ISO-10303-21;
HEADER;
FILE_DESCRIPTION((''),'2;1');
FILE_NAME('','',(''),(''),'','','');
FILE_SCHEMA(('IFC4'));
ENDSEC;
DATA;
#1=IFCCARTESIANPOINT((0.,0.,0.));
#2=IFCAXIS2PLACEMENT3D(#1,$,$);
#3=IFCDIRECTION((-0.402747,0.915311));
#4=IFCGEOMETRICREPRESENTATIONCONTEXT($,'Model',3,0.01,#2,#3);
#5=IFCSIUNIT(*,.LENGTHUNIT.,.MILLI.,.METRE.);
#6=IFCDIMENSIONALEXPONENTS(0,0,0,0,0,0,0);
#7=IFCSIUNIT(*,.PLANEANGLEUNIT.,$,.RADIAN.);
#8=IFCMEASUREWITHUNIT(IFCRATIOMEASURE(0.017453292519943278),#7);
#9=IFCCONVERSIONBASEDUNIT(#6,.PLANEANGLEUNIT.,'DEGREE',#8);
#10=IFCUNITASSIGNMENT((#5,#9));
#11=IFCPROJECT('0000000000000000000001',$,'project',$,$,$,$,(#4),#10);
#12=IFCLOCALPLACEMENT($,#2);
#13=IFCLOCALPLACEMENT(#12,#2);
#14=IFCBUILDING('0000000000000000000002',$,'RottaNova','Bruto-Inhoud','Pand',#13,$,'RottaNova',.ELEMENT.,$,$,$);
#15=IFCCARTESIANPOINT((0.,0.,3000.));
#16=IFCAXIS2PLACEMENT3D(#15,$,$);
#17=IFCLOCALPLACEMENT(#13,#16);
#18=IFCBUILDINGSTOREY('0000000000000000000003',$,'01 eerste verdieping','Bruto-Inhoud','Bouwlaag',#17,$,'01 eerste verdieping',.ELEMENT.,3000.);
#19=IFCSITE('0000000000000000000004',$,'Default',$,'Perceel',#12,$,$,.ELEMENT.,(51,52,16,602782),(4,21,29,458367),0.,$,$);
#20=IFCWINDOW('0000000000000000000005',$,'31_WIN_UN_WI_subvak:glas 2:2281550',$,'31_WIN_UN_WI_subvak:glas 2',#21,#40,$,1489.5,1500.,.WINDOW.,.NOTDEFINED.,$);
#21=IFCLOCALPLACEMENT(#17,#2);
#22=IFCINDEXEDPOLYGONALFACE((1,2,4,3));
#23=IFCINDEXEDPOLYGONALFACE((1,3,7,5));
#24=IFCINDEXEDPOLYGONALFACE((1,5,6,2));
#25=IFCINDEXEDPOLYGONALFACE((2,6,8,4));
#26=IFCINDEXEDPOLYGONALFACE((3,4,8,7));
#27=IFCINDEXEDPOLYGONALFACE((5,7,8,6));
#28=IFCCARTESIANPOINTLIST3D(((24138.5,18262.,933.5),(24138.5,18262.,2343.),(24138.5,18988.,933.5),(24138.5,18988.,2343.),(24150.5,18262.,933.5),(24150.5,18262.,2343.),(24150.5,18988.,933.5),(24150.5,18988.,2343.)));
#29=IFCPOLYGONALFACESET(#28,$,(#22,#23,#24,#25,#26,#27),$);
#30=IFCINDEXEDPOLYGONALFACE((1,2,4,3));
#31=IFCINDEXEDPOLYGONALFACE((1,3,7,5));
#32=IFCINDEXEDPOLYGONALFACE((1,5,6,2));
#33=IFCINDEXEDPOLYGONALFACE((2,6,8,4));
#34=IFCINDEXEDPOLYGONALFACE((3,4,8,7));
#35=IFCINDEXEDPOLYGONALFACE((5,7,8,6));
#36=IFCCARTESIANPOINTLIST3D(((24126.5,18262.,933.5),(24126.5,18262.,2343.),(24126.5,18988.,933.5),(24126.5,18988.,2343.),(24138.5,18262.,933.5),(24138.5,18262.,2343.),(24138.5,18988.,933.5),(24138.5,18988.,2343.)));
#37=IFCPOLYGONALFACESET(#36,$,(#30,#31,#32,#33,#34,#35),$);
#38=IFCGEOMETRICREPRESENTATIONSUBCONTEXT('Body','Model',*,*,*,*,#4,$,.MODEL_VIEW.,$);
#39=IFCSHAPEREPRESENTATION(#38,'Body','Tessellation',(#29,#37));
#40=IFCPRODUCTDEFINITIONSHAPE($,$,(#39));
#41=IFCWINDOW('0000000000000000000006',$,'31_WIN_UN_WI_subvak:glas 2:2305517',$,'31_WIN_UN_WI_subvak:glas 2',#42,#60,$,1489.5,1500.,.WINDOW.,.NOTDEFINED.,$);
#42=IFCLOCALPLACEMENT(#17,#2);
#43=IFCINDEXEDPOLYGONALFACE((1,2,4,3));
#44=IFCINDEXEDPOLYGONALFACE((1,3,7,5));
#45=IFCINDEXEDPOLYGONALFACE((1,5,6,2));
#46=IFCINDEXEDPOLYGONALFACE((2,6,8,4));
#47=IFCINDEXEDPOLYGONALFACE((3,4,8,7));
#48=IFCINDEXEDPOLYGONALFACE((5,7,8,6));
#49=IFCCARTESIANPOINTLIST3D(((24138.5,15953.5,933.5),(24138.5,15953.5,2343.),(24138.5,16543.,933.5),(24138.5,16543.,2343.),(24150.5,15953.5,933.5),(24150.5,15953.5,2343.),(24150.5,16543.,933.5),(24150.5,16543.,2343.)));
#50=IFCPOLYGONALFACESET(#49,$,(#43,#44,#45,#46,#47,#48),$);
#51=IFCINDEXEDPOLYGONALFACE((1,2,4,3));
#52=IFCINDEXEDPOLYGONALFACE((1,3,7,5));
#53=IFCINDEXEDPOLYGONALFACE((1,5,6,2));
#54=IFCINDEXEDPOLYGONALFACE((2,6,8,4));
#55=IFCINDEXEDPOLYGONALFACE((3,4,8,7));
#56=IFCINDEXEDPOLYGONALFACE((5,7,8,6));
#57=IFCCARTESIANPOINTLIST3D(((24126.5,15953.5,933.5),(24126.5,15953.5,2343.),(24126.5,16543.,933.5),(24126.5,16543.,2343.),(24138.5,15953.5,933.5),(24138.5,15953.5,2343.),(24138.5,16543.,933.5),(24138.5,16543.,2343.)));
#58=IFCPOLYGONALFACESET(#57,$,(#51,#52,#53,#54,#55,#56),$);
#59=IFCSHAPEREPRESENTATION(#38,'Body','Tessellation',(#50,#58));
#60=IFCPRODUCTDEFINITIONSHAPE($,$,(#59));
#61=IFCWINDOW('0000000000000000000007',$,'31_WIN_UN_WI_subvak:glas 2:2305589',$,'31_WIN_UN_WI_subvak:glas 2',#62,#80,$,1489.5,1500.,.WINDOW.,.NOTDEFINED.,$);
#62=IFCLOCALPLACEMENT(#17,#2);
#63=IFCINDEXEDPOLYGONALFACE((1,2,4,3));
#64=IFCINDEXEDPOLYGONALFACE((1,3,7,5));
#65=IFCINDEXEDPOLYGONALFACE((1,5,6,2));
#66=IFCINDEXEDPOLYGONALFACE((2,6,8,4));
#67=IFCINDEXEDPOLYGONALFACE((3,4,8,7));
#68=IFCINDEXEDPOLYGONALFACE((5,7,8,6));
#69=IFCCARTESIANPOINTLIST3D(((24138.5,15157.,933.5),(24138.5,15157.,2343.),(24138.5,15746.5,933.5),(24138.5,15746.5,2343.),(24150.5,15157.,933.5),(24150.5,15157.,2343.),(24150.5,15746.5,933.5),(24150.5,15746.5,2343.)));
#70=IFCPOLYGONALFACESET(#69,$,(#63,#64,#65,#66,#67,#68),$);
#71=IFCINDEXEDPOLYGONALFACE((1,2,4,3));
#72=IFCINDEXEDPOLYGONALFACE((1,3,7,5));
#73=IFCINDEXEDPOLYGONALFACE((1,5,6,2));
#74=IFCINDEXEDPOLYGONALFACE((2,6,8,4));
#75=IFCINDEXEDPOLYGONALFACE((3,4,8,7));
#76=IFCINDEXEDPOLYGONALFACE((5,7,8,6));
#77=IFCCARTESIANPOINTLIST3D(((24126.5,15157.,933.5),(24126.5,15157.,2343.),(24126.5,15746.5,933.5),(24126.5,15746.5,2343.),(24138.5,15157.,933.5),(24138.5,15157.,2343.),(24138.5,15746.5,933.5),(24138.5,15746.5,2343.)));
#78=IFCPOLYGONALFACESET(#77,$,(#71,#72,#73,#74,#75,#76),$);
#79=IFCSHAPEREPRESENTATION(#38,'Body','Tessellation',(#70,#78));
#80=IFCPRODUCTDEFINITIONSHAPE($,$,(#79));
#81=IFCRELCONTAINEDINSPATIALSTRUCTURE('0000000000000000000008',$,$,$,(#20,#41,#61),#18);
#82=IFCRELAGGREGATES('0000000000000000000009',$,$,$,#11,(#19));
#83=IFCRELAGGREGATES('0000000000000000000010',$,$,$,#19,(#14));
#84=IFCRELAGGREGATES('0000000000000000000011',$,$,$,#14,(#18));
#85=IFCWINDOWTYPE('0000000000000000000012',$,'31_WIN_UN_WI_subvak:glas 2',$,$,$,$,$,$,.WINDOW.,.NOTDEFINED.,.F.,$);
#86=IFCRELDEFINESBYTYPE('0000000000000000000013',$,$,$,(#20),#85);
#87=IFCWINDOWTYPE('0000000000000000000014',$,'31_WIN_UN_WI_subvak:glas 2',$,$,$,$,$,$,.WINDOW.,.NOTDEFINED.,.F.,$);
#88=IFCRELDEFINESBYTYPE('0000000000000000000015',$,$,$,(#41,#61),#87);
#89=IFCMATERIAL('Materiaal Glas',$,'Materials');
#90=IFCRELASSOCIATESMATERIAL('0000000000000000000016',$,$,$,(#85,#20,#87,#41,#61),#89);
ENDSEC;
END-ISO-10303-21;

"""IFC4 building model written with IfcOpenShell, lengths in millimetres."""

from ifc_helpers import new_model, entity, si_unit, converted_unit, direction, frame, frame_2d, origin, origin_2d_with_axis, place, context, subcontext, project, spatial, rectangle, extrude, source, transform, mapped, material, type_object, type_shapes, element, save


model = new_model("IFC4")

# Units and contexts
model_context = context("Model", 3, precision=0.01, world=origin(), true_north=direction((-0.402747, 0.915311)))
body_context = subcontext(model_context, "Body", "Model", "MODEL_VIEW")
ifc_project = project(units=[si_unit("LENGTHUNIT", "METRE", prefix="MILLI"), converted_unit("PLANEANGLEUNIT", "DEGREE", entity("IfcRatioMeasure", 0.017453292519943278), si_unit("PLANEANGLEUNIT", "RADIAN"), dimensions=[0, 0, 0, 0, 0, 0, 0])], contexts=[model_context])

# Site, building, storey
site_placement = place(None, origin())
site = spatial("IfcSite", under=ifc_project, at=site_placement, Name="Default", ObjectType="Perceel", CompositionType="ELEMENT", RefLatitude=(51, 52, 16, 602782), RefLongitude=(4, 21, 29, 458367), RefElevation=0.0)
building_placement = place(site_placement, origin())
building = spatial("IfcBuilding", under=site, at=building_placement, Name="RottaNova", Description="Bruto-Inhoud", ObjectType="Pand", LongName="RottaNova", CompositionType="ELEMENT")
storey_placement = place(building_placement, frame((0.0, 0.0, 3000.0)))
storey = spatial("IfcBuildingStorey", under=building, at=storey_placement, Name="01 eerste verdieping", Description="Bruto-Inhoud", ObjectType="Bouwlaag", LongName="01 eerste verdieping", CompositionType="ELEMENT", Elevation=3000.0)

# Shared definitions
ifc_material_1 = material(Name="Materiaal Glas", Category="Materials")

# Windows
window_type_1 = type_object("IfcWindowType", Name="31_WIN_UN_WI_subvak:glas 2", ParameterTakesPrecedence=False, PartitioningType="NOTDEFINED", PredefinedType="WINDOW", material=ifc_material_1)
shared_shape_1 = source(origin(), body_context, "Body", "SweptSolid", [
    extrude(rectangle(XDim=726.0, YDim=12.0, at=origin_2d_with_axis()), frame((0.0, -6.0, 0.0)), (0.0, 0.0, 1.0), 1409.5),
    extrude(rectangle(XDim=726.0, YDim=12.0, at=origin_2d_with_axis()), frame((0.0, 6.0, 0.0)), (0.0, 0.0, 1.0), 1409.5),
])
type_shapes(window_type_1, [shared_shape_1])
window_1_placement = place(storey_placement, frame((24138.5, 18625.0, 933.5), z_axis=(0.0, 0.0, 1.0), x_axis=(0.0, 1.0, 0.0)))
element("IfcWindow", 1, at=window_1_placement, inside=storey, type_object=window_type_1, material=ifc_material_1, Name="31_WIN_UN_WI_subvak:glas 2:2281550", ObjectType="31_WIN_UN_WI_subvak:glas 2", OverallHeight=1489.5, OverallWidth=1500.0, PartitioningType="NOTDEFINED", PredefinedType="WINDOW", context=body_context, shape_type="MappedRepresentation", body=[
    mapped(shared_shape_1, transform((0.0, 0.0, 0.0), scale=1.0)),
])
window_type_2 = type_object("IfcWindowType", Name="31_WIN_UN_WI_subvak:glas 2", ParameterTakesPrecedence=False, PartitioningType="NOTDEFINED", PredefinedType="WINDOW", material=ifc_material_1)
shared_shape_2 = source(origin(), body_context, "Body", "SweptSolid", [
    extrude(rectangle(XDim=12.0, YDim=589.5, at=frame_2d((0.0, 0.0), x_axis=(1.0, 0.0))), frame((0.0, 6.0, 0.0), z_axis=(0.0, 0.0, 1.0), x_axis=(0.0, -1.0, 0.0)), (0.0, 0.0, 1.0), 1409.5),
    extrude(rectangle(XDim=12.0, YDim=589.5, at=frame_2d((0.0, 0.0), x_axis=(1.0, 0.0))), frame((0.0, -6.0, 0.0), z_axis=(0.0, 0.0, 1.0), x_axis=(0.0, -1.0, 0.0)), (0.0, 0.0, 1.0), 1409.5),
])
type_shapes(window_type_2, [shared_shape_2])
for number, where, z_axis, x_axis, name in (
    (2, (24138.5, 16248.3, 933.5), (0.0, 0.0, 1.0), (0.0, -1.0, 0.0), "31_WIN_UN_WI_subvak:glas 2:2305517"),
    (3, (24138.5, 15451.8, 933.5), (0.0, 0.0, 1.0), (0.0, -1.0, 0.0), "31_WIN_UN_WI_subvak:glas 2:2305589"),
):
    element("IfcWindow", number, at=place(storey_placement, frame(where, z_axis=z_axis, x_axis=x_axis)), inside=storey, type_object=window_type_2, material=ifc_material_1, Name=name, ObjectType="31_WIN_UN_WI_subvak:glas 2", OverallHeight=1489.5, OverallWidth=1500.0, PartitioningType="NOTDEFINED", PredefinedType="WINDOW", context=body_context, shape_type="MappedRepresentation", body=[
        mapped(shared_shape_2, transform((0.0, 0.0, 0.0), scale=1.0)),
    ])

save(model, "model.ifc")
